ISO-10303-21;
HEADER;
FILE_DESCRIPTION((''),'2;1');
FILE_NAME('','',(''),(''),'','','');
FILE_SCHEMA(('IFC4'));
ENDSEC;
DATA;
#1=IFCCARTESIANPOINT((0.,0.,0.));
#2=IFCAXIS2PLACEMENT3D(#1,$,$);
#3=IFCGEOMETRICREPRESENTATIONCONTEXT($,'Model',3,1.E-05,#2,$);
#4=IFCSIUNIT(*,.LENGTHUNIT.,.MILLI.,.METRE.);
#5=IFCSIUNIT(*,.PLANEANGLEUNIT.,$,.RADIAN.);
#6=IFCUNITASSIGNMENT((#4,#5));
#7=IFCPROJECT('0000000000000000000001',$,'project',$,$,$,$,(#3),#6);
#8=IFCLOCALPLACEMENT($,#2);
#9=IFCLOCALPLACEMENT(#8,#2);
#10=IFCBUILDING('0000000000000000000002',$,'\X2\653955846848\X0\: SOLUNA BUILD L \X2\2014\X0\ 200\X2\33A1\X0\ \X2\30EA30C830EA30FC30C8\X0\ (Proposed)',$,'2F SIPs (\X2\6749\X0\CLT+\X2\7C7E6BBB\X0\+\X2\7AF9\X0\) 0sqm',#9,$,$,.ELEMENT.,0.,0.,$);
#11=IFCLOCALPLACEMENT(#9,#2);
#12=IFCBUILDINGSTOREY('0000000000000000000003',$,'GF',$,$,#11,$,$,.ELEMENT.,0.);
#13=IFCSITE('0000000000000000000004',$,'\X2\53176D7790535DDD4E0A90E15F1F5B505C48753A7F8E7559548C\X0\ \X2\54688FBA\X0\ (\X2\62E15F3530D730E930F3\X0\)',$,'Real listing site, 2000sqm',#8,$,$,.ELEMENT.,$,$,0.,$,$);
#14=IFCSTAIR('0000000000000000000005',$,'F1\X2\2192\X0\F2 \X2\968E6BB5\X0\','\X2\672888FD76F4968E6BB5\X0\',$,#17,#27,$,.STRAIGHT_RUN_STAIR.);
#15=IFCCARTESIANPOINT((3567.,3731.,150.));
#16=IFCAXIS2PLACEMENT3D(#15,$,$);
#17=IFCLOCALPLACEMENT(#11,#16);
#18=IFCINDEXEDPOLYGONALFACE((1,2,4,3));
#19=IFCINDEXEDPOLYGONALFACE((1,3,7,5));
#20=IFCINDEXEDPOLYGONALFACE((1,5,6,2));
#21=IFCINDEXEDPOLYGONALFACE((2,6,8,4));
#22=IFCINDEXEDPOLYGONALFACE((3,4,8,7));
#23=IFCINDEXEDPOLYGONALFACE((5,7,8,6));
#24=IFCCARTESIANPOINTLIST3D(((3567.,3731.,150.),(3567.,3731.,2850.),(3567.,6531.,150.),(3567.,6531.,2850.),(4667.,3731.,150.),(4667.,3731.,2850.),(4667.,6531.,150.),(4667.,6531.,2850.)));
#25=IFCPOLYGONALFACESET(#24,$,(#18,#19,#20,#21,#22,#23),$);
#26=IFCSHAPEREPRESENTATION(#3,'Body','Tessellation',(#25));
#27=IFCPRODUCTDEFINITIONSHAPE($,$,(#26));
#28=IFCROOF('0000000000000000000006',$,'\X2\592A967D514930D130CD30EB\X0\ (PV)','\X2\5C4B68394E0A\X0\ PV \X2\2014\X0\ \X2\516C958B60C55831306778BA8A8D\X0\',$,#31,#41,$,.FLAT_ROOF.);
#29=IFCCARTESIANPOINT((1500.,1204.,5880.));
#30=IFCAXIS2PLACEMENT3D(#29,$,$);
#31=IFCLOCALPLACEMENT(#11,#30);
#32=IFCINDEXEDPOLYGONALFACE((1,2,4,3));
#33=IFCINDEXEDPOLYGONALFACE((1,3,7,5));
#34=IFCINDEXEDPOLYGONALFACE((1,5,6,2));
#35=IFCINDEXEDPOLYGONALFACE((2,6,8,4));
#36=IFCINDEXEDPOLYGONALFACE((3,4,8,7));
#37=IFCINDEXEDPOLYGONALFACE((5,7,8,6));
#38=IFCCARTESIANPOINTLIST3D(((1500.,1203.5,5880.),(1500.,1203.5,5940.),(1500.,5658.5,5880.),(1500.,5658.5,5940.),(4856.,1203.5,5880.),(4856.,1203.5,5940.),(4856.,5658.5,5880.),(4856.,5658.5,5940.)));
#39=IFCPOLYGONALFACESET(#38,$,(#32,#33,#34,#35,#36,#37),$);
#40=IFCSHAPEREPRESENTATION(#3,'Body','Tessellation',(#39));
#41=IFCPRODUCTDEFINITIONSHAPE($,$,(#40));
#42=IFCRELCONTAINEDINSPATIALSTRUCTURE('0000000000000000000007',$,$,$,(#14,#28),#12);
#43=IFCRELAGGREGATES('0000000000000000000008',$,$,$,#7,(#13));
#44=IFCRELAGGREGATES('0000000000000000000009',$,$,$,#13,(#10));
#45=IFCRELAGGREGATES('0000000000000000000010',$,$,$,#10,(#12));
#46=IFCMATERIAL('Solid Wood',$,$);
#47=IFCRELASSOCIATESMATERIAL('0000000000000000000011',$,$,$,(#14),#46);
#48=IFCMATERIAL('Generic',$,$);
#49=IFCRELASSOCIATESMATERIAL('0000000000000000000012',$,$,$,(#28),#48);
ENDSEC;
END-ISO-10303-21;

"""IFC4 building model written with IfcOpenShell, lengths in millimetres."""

from ifc_helpers import new_model, si_unit, frame, frame_2d, origin, place, context, project, spatial, rectangle, extrude, material, element, save


model = new_model("IFC4")

# Units and contexts
model_context = context("Model", 3, precision=1e-05, world=origin())
ifc_project = project(units=[si_unit("LENGTHUNIT", "METRE", prefix="MILLI"), si_unit("PLANEANGLEUNIT", "RADIAN")], contexts=[model_context])

# Site, building, storey
site_placement = place(None, origin())
site = spatial("IfcSite", under=ifc_project, at=site_placement, Name="北海道川上郡弟子屈町美留和 周辺 (拡張プラン)", ObjectType="Real listing site, 2000sqm", CompositionType="ELEMENT", RefElevation=0.0)
building_placement = place(site_placement, origin())
building = spatial("IfcBuilding", under=site, at=building_placement, Name="改善案: SOLUNA BUILD L — 200㎡ リトリート (Proposed)", ObjectType="2F SIPs (杉CLT+籾殻+竹) 0sqm", CompositionType="ELEMENT", ElevationOfRefHeight=0.0, ElevationOfTerrain=0.0)
storey_placement = place(building_placement, origin())
storey = spatial("IfcBuildingStorey", under=building, at=storey_placement, Name="GF", CompositionType="ELEMENT", Elevation=0.0)

# Shared definitions
ifc_material_1 = material(Name="Generic")

# Stair
ifc_material_2 = material(Name="Solid Wood")
stair_placement = place(storey_placement, frame((3567.0, 3731.0, 150.0)))
element("IfcStair", 1, at=stair_placement, inside=storey, material=ifc_material_2, Name="F1→F2 階段", Description="木製直階段", PredefinedType="STRAIGHT_RUN_STAIR", context=model_context, shape_type="SweptSolid", body=[
    extrude(rectangle(XDim=1100.0, YDim=2800.0, at=frame_2d((550.0, 1400.0))), frame((3567.0, 3731.0, 150.0)), (0.0, 0.0, 1.0), 2700.0),
])

# Roof
roof_placement = place(storey_placement, frame((1500.0, 1204.0, 5880.0)))
element("IfcRoof", 2, at=roof_placement, inside=storey, material=ifc_material_1, Name="太陽光パネル (PV)", Description="屋根上 PV — 公開情報で確認", PredefinedType="FLAT_ROOF", context=model_context, shape_type="SweptSolid", body=[
    extrude(rectangle(XDim=3356.0, YDim=4455.0, at=frame_2d((1678.0, 2227.0))), frame((1500.0, 1204.0, 5880.0)), (0.0, 0.0, 1.0), 60.0),
])

save(model, "model.ifc")
